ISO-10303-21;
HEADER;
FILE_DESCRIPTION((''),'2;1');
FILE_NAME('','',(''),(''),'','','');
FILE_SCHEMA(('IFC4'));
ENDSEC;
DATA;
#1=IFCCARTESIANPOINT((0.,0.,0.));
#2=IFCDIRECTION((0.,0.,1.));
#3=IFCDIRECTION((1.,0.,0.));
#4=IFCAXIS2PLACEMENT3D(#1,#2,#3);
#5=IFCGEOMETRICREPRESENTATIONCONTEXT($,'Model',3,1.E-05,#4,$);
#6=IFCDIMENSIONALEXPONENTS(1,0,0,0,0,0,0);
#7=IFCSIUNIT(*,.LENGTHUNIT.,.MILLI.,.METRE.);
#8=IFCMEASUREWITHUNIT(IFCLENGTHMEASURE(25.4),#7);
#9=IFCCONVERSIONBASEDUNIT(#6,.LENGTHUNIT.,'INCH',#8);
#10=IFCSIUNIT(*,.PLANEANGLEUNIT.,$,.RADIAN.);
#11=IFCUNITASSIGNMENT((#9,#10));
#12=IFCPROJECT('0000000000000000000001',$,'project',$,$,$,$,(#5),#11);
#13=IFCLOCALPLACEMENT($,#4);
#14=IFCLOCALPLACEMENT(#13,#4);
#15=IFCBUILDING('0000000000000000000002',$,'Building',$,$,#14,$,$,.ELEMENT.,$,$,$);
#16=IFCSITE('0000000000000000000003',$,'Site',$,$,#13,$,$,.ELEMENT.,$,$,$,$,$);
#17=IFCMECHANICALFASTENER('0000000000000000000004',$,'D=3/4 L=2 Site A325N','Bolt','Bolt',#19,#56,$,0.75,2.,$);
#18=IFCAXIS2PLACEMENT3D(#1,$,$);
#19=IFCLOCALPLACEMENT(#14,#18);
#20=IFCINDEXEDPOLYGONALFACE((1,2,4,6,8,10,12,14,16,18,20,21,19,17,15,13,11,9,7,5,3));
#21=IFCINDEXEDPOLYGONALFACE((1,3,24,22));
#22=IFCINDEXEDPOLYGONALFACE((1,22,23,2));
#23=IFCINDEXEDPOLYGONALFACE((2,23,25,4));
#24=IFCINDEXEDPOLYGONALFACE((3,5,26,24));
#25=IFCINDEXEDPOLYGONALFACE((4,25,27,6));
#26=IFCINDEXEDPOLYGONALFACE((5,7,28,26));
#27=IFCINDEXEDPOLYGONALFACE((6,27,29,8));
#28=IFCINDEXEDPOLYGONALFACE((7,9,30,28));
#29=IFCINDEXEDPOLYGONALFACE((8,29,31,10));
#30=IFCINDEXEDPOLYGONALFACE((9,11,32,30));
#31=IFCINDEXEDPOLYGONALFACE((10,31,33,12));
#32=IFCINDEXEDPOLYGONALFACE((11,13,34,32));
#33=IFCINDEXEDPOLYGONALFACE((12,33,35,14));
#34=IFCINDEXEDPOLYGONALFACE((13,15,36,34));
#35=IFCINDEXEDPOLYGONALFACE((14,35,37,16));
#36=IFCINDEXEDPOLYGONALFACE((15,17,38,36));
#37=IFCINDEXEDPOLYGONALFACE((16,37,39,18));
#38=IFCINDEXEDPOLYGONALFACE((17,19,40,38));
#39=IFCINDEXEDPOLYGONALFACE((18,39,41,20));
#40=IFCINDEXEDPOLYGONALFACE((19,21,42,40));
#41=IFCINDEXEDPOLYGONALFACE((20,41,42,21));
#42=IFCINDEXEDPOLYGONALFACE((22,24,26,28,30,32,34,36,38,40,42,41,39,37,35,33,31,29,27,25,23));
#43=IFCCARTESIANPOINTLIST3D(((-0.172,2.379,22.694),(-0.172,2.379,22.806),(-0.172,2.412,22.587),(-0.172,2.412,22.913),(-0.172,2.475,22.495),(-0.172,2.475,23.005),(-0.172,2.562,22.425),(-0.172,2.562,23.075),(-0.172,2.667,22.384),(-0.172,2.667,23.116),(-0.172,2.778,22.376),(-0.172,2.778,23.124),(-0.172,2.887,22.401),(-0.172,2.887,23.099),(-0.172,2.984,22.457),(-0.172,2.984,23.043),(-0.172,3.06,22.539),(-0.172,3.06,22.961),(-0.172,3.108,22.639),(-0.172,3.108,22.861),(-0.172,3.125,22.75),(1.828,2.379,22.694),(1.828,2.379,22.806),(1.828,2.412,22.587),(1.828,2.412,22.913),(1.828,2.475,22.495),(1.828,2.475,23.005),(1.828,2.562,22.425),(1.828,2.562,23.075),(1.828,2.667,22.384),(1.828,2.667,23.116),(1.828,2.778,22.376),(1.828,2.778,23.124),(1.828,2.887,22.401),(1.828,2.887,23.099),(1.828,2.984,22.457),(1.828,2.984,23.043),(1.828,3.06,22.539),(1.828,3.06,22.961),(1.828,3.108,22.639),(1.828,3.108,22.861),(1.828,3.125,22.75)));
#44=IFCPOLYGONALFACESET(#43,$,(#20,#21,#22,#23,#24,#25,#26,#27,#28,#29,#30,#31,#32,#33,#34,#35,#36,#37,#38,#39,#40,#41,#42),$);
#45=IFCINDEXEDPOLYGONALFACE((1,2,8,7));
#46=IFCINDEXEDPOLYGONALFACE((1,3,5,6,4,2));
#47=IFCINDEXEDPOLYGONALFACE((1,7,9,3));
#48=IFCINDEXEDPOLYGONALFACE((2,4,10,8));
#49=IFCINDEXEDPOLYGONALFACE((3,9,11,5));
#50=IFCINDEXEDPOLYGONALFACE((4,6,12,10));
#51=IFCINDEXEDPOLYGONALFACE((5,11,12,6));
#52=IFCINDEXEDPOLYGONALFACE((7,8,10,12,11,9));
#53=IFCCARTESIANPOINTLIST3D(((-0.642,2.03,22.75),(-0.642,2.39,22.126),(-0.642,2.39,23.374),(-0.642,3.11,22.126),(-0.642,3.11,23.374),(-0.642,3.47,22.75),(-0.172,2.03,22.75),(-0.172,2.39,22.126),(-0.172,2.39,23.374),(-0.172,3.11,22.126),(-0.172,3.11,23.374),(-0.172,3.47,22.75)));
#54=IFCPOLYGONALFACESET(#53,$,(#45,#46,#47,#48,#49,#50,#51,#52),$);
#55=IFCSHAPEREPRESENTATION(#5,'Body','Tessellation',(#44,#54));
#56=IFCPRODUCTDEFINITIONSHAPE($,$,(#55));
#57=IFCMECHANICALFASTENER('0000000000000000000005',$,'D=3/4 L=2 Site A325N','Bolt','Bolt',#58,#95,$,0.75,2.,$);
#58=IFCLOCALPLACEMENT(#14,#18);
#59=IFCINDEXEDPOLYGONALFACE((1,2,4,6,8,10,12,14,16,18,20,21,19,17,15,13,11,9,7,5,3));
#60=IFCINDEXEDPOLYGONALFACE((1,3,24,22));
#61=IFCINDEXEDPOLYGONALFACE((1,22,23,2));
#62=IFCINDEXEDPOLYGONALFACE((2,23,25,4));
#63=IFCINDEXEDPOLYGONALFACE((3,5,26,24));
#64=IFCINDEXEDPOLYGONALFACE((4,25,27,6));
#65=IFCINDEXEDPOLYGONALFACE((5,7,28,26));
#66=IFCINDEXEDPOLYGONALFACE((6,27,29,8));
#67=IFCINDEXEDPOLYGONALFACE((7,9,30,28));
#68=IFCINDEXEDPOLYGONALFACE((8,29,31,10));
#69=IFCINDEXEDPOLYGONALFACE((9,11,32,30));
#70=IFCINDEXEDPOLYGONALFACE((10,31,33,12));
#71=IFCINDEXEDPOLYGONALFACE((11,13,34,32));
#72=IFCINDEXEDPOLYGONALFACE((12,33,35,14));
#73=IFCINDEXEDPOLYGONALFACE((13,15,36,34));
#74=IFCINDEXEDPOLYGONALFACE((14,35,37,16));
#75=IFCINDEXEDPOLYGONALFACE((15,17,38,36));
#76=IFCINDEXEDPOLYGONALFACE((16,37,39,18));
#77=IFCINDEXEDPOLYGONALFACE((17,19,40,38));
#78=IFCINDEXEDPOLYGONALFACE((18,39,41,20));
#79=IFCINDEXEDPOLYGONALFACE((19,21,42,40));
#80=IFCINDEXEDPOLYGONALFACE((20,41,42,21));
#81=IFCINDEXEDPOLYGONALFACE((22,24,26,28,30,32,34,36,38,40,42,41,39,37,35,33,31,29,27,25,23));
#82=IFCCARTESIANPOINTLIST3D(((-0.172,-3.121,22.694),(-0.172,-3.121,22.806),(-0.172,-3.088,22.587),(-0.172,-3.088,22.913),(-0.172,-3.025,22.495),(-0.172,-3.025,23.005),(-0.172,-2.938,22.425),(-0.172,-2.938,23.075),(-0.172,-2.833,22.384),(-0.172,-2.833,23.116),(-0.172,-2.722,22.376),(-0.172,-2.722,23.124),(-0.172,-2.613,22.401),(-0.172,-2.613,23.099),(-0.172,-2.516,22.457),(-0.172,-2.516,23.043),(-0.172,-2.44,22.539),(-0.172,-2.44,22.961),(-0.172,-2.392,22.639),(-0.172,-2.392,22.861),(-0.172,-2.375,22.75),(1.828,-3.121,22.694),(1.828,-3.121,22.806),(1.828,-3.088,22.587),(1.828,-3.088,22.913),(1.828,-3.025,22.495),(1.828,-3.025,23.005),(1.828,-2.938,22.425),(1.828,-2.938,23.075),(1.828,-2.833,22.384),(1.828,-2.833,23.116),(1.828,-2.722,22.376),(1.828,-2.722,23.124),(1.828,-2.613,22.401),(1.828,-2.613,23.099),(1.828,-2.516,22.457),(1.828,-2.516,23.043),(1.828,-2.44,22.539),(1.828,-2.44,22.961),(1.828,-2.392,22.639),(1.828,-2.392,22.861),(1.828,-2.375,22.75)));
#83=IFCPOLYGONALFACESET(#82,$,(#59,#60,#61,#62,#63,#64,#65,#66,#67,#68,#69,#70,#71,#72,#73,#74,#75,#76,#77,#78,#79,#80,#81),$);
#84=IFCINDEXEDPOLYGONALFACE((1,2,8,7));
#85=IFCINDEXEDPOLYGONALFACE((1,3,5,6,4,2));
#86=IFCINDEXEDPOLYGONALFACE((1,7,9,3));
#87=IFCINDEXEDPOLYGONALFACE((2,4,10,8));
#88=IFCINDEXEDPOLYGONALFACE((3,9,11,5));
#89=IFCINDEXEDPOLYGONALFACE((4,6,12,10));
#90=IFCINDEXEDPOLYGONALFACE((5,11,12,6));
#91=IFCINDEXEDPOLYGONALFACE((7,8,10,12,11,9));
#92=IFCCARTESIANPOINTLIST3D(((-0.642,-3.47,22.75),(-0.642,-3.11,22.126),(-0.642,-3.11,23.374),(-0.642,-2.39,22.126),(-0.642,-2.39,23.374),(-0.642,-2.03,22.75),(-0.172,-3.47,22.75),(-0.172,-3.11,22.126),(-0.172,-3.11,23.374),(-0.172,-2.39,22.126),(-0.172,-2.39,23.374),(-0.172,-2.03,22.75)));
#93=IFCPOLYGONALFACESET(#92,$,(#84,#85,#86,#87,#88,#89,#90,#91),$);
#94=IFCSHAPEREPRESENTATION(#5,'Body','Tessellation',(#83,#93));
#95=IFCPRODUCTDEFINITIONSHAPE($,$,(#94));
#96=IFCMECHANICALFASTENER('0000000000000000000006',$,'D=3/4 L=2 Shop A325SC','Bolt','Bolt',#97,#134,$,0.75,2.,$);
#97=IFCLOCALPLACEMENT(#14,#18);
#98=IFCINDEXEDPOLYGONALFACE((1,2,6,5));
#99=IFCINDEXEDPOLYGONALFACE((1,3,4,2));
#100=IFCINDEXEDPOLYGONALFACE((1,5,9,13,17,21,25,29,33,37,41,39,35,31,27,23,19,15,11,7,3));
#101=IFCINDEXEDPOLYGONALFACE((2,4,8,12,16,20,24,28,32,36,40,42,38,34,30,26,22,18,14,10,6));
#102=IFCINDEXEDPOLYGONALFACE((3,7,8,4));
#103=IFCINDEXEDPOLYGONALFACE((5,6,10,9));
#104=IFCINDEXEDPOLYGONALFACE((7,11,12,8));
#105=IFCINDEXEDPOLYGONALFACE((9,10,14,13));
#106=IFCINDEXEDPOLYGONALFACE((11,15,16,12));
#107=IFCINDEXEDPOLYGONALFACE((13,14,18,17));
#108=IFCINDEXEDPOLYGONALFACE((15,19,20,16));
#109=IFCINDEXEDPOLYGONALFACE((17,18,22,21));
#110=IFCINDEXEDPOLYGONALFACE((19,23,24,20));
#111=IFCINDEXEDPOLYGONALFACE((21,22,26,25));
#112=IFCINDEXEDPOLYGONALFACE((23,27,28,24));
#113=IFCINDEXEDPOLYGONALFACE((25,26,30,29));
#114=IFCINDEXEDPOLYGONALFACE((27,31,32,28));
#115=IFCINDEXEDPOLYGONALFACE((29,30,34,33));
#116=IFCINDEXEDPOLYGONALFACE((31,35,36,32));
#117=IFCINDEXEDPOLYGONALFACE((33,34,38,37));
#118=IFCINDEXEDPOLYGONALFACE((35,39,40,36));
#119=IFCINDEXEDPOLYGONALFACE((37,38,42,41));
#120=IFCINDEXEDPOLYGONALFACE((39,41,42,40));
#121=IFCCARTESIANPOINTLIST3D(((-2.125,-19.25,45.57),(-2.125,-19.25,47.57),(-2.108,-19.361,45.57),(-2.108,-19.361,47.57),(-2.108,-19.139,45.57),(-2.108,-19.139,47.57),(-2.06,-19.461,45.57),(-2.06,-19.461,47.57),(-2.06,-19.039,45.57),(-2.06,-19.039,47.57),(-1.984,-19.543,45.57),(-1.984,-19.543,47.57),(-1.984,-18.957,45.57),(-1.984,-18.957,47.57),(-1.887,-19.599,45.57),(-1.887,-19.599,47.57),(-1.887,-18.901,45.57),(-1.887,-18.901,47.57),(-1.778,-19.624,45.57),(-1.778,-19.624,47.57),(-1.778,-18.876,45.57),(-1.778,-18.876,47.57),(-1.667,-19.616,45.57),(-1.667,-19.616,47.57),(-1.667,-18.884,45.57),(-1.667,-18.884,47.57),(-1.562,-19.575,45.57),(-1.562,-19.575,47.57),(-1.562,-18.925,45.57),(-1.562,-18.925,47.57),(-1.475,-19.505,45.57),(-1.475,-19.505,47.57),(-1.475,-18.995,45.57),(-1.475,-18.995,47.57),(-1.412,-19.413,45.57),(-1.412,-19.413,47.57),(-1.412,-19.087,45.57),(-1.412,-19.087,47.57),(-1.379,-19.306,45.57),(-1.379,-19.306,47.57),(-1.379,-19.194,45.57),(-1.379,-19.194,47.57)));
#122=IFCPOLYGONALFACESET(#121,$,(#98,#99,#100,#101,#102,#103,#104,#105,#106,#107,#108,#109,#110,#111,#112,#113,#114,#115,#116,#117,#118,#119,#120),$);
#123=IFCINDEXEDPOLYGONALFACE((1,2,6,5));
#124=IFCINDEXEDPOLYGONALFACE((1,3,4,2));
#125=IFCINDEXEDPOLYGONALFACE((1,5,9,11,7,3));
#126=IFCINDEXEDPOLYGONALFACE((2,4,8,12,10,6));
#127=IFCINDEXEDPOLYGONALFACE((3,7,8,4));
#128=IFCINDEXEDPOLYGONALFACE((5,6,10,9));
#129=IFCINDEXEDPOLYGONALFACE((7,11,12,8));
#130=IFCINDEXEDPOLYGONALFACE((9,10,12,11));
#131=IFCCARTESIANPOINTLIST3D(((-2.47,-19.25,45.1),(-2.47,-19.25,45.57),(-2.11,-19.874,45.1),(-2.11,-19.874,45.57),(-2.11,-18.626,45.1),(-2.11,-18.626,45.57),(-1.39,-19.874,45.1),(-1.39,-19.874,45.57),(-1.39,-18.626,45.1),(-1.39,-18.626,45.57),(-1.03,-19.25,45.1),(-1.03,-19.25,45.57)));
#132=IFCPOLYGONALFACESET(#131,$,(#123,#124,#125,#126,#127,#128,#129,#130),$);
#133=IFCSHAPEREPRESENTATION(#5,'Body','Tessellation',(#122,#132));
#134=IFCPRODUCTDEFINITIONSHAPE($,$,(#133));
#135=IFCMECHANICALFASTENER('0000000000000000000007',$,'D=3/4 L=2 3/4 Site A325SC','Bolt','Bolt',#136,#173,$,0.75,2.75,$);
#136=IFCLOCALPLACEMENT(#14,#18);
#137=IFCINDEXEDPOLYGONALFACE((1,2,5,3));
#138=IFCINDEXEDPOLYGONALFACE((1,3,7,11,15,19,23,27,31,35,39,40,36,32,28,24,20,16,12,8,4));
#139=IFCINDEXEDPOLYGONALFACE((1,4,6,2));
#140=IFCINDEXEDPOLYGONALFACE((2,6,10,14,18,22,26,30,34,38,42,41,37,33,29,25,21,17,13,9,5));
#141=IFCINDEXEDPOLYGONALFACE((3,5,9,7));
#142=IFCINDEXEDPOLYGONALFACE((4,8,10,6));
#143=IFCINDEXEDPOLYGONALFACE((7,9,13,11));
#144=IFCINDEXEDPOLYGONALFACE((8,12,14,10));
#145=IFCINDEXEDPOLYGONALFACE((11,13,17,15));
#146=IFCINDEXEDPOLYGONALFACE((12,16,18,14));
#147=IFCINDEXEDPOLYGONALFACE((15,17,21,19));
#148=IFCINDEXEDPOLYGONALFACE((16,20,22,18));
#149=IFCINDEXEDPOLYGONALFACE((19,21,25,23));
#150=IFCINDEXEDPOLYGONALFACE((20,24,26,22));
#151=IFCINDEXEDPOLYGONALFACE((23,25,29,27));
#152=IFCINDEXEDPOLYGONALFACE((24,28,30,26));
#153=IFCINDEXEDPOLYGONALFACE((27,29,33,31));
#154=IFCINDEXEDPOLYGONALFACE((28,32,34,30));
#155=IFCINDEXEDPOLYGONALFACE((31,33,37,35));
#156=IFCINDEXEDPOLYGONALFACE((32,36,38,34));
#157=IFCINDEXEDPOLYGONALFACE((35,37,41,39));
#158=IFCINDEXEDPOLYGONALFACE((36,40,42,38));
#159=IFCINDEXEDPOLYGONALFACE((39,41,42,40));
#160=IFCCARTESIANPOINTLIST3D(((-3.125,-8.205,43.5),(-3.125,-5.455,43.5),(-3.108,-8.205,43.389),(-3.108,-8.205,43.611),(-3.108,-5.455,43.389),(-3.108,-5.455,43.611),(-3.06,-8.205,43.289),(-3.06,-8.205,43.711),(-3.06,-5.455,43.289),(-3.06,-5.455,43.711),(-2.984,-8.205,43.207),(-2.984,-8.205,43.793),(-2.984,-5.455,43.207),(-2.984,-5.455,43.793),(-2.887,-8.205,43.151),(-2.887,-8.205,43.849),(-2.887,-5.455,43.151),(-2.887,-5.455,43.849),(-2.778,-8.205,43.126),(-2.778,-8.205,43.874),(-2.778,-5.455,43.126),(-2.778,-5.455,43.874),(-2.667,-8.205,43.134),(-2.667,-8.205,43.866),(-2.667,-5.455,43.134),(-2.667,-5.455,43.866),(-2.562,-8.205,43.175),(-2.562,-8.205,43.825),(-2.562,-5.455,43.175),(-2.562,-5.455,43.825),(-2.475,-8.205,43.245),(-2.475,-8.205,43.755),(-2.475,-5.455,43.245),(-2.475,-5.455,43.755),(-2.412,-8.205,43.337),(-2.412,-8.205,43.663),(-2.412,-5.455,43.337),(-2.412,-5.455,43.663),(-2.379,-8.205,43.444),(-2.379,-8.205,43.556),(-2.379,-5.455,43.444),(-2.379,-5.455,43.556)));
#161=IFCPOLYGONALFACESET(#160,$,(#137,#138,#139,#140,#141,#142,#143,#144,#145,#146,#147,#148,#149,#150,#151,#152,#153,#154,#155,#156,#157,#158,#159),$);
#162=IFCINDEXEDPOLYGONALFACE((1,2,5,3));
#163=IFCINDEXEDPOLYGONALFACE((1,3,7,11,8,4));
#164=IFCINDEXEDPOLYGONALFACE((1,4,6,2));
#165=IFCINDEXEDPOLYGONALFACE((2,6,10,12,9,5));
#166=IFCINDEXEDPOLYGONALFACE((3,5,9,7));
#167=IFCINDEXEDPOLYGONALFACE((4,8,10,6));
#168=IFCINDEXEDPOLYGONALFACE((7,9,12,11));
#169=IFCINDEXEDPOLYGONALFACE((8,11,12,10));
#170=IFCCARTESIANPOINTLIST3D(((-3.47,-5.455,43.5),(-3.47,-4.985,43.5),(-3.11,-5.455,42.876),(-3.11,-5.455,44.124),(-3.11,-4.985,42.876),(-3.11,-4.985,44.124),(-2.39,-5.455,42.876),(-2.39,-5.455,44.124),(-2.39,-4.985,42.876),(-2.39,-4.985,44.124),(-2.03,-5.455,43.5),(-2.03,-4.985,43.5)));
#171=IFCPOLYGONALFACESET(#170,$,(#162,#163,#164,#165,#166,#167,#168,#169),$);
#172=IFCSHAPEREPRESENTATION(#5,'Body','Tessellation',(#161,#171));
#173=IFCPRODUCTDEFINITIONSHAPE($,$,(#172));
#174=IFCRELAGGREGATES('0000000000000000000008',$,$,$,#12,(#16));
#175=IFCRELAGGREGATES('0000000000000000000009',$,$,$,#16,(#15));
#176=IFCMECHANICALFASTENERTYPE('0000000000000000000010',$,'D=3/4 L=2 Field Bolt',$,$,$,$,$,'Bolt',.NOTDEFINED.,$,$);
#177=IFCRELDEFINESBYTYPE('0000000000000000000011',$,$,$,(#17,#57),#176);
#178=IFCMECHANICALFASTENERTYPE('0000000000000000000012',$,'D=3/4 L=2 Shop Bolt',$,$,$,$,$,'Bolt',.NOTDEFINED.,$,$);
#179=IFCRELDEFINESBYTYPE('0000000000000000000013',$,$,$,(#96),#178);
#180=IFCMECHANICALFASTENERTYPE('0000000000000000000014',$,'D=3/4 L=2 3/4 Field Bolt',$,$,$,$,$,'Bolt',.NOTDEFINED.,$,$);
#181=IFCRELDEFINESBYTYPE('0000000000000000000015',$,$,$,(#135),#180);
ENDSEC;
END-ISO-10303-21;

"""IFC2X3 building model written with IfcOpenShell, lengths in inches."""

from ifc_helpers import new_model, entity, si_unit, converted_unit, frame, origin_with_axes, origin_2d_with_axis, place, context, project, spatial, polyline, circle, outline, extrude, source, transform, mapped, type_object, type_shapes, element, save


model = new_model("IFC2X3")

# Units and contexts
model_context = context("Model", 3, precision=1e-05, world=origin_with_axes())
ifc_project = project(units=[converted_unit("LENGTHUNIT", "INCH", entity("IfcLengthMeasure", 25.4), si_unit("LENGTHUNIT", "METRE", prefix="MILLI"), dimensions=[1, 0, 0, 0, 0, 0, 0]), si_unit("PLANEANGLEUNIT", "RADIAN")], contexts=[model_context])

# Site, building
site_placement = place(None, origin_with_axes())
site = spatial("IfcSite", under=ifc_project, at=site_placement, Name="Site", CompositionType="ELEMENT")
building_placement = place(site_placement, origin_with_axes())
building = spatial("IfcBuilding", under=site, at=building_placement, Name="Building", CompositionType="ELEMENT")

# Mechanical fasteners
placement_1 = place(building_placement, frame((0.0, 0.0, 21.0), z_axis=(0.0, -1.0, 0.0), x_axis=(0.0, 0.0, 1.0)))
mechanical_fastener_type_1 = type_object("IfcMechanicalFastenerType", Name="D=3/4 L=2 Field Bolt", ElementType="Bolt")
shared_shape_1 = source(origin_with_axes(), model_context, "Body", "SweptSolid", [
    extrude(circle(Radius=0.375, at=origin_2d_with_axis()), frame((0.0, 0.0, 0.0), z_axis=(1.0, 0.0, 0.0), x_axis=(0.0, 1.0, 0.0)), (0.0, 0.0, 1.0), 2.0),
    extrude(outline(polyline([(-0.72, 0.0), (-0.36, 0.624), (0.36, 0.624), (0.72, 0.0), (0.36, -0.624), (-0.36, -0.624), (-0.72, 0.0)])), frame((0.0, 0.0, 0.0), z_axis=(1.0, 0.0, 0.0), x_axis=(0.0, 1.0, 0.0)), (0.0, 0.0, -1.0), 0.47),
])
type_shapes(mechanical_fastener_type_1, [shared_shape_1])
placement_2 = place(placement_1, frame((1.75, 0.172, -2.75), z_axis=(1.0, 0.0, 0.0), x_axis=(0.0, -1.0, 0.0)))
for number, where, z_axis, x_axis, name in (
    (1, (0.0, 0.0, 0.0), (0.0, 0.0, 1.0), (1.0, 0.0, 0.0), "D=3/4 L=2 Site A325N"),
    (2, (0.0, -5.5, 0.0), (0.0, 0.0, 1.0), (1.0, 0.0, 0.0), "D=3/4 L=2 Site A325N"),
):
    element("IfcMechanicalFastener", number, at=place(placement_2, frame(where, z_axis=z_axis, x_axis=x_axis)), type_object=mechanical_fastener_type_1, Name=name, Description="Bolt", ObjectType="Bolt", NominalDiameter=0.75, NominalLength=2.0, context=model_context, shape_type="MappedRepresentation", body=[
        mapped(shared_shape_1, transform((0.0, 0.0, 0.0), scale=1.0)),
    ])
mechanical_fastener_type_2 = type_object("IfcMechanicalFastenerType", Name="D=3/4 L=2 Shop Bolt", ElementType="Bolt")
shared_shape_2 = source(origin_with_axes(), model_context, "Body", "SweptSolid", [
    extrude(circle(Radius=0.375, at=origin_2d_with_axis()), frame((0.0, 0.0, 0.0), z_axis=(1.0, 0.0, 0.0), x_axis=(0.0, 1.0, 0.0)), (0.0, 0.0, 1.0), 2.0),
    extrude(outline(polyline([(-0.72, 0.0), (-0.36, 0.624), (0.36, 0.624), (0.72, 0.0), (0.36, -0.624), (-0.36, -0.624), (-0.72, 0.0)])), frame((0.0, 0.0, 0.0), z_axis=(1.0, 0.0, 0.0), x_axis=(0.0, 1.0, 0.0)), (0.0, 0.0, -1.0), 0.47),
])
type_shapes(mechanical_fastener_type_2, [shared_shape_2])
placement_3 = place(building_placement, frame((0.0, 0.0, 46.0), z_axis=(0.0, 0.0, 1.0), x_axis=(0.0, -1.0, 0.0)))
placement_4 = place(placement_3, frame((25.25, -1.75, -0.43), z_axis=(1.0, 0.0, 0.0), x_axis=(0.0, 0.0, 1.0)))
mechanical_fastener_placement = place(placement_4, frame((0.0, 0.0, -6.0), z_axis=(0.0, 0.0, 1.0), x_axis=(1.0, 0.0, 0.0)))
element("IfcMechanicalFastener", 3, at=mechanical_fastener_placement, type_object=mechanical_fastener_type_2, Name="D=3/4 L=2 Shop A325SC", Description="Bolt", ObjectType="Bolt", NominalDiameter=0.75, NominalLength=2.0, context=model_context, shape_type="MappedRepresentation", body=[
    mapped(shared_shape_2, transform((0.0, 0.0, 0.0), scale=1.0)),
])
mechanical_fastener_type_3 = type_object("IfcMechanicalFastenerType", Name="D=3/4 L=2 3/4 Field Bolt", ElementType="Bolt")
shared_shape_3 = source(origin_with_axes(), model_context, "Body", "SweptSolid", [
    extrude(circle(Radius=0.375, at=origin_2d_with_axis()), frame((0.0, 0.0, 0.0), z_axis=(1.0, 0.0, 0.0), x_axis=(0.0, 1.0, 0.0)), (0.0, 0.0, 1.0), 2.75),
    extrude(outline(polyline([(-0.72, 0.0), (-0.36, 0.624), (0.36, 0.624), (0.72, 0.0), (0.36, -0.624), (-0.36, -0.624), (-0.72, 0.0)])), frame((0.0, 0.0, 0.0), z_axis=(1.0, 0.0, 0.0), x_axis=(0.0, 1.0, 0.0)), (0.0, 0.0, -1.0), 0.47),
])
type_shapes(mechanical_fastener_type_3, [shared_shape_3])
placement_5 = place(placement_3, frame((5.455, -2.75, 2.0), z_axis=(0.0, 0.0, -1.0), x_axis=(1.0, 0.0, 0.0)))
for number, where, z_axis, x_axis, name in (
    (4, (0.0, 0.0, 4.5), (0.0, 0.0, 1.0), (1.0, 0.0, 0.0), "D=3/4 L=2 3/4 Site A325SC"),
):
    element("IfcMechanicalFastener", number, at=place(placement_5, frame(where, z_axis=z_axis, x_axis=x_axis)), type_object=mechanical_fastener_type_3, Name=name, Description="Bolt", ObjectType="Bolt", NominalDiameter=0.75, NominalLength=2.75, context=model_context, shape_type="MappedRepresentation", body=[
        mapped(shared_shape_3, transform((0.0, 0.0, 0.0), scale=1.0)),
    ])

save(model, "model.ifc")
